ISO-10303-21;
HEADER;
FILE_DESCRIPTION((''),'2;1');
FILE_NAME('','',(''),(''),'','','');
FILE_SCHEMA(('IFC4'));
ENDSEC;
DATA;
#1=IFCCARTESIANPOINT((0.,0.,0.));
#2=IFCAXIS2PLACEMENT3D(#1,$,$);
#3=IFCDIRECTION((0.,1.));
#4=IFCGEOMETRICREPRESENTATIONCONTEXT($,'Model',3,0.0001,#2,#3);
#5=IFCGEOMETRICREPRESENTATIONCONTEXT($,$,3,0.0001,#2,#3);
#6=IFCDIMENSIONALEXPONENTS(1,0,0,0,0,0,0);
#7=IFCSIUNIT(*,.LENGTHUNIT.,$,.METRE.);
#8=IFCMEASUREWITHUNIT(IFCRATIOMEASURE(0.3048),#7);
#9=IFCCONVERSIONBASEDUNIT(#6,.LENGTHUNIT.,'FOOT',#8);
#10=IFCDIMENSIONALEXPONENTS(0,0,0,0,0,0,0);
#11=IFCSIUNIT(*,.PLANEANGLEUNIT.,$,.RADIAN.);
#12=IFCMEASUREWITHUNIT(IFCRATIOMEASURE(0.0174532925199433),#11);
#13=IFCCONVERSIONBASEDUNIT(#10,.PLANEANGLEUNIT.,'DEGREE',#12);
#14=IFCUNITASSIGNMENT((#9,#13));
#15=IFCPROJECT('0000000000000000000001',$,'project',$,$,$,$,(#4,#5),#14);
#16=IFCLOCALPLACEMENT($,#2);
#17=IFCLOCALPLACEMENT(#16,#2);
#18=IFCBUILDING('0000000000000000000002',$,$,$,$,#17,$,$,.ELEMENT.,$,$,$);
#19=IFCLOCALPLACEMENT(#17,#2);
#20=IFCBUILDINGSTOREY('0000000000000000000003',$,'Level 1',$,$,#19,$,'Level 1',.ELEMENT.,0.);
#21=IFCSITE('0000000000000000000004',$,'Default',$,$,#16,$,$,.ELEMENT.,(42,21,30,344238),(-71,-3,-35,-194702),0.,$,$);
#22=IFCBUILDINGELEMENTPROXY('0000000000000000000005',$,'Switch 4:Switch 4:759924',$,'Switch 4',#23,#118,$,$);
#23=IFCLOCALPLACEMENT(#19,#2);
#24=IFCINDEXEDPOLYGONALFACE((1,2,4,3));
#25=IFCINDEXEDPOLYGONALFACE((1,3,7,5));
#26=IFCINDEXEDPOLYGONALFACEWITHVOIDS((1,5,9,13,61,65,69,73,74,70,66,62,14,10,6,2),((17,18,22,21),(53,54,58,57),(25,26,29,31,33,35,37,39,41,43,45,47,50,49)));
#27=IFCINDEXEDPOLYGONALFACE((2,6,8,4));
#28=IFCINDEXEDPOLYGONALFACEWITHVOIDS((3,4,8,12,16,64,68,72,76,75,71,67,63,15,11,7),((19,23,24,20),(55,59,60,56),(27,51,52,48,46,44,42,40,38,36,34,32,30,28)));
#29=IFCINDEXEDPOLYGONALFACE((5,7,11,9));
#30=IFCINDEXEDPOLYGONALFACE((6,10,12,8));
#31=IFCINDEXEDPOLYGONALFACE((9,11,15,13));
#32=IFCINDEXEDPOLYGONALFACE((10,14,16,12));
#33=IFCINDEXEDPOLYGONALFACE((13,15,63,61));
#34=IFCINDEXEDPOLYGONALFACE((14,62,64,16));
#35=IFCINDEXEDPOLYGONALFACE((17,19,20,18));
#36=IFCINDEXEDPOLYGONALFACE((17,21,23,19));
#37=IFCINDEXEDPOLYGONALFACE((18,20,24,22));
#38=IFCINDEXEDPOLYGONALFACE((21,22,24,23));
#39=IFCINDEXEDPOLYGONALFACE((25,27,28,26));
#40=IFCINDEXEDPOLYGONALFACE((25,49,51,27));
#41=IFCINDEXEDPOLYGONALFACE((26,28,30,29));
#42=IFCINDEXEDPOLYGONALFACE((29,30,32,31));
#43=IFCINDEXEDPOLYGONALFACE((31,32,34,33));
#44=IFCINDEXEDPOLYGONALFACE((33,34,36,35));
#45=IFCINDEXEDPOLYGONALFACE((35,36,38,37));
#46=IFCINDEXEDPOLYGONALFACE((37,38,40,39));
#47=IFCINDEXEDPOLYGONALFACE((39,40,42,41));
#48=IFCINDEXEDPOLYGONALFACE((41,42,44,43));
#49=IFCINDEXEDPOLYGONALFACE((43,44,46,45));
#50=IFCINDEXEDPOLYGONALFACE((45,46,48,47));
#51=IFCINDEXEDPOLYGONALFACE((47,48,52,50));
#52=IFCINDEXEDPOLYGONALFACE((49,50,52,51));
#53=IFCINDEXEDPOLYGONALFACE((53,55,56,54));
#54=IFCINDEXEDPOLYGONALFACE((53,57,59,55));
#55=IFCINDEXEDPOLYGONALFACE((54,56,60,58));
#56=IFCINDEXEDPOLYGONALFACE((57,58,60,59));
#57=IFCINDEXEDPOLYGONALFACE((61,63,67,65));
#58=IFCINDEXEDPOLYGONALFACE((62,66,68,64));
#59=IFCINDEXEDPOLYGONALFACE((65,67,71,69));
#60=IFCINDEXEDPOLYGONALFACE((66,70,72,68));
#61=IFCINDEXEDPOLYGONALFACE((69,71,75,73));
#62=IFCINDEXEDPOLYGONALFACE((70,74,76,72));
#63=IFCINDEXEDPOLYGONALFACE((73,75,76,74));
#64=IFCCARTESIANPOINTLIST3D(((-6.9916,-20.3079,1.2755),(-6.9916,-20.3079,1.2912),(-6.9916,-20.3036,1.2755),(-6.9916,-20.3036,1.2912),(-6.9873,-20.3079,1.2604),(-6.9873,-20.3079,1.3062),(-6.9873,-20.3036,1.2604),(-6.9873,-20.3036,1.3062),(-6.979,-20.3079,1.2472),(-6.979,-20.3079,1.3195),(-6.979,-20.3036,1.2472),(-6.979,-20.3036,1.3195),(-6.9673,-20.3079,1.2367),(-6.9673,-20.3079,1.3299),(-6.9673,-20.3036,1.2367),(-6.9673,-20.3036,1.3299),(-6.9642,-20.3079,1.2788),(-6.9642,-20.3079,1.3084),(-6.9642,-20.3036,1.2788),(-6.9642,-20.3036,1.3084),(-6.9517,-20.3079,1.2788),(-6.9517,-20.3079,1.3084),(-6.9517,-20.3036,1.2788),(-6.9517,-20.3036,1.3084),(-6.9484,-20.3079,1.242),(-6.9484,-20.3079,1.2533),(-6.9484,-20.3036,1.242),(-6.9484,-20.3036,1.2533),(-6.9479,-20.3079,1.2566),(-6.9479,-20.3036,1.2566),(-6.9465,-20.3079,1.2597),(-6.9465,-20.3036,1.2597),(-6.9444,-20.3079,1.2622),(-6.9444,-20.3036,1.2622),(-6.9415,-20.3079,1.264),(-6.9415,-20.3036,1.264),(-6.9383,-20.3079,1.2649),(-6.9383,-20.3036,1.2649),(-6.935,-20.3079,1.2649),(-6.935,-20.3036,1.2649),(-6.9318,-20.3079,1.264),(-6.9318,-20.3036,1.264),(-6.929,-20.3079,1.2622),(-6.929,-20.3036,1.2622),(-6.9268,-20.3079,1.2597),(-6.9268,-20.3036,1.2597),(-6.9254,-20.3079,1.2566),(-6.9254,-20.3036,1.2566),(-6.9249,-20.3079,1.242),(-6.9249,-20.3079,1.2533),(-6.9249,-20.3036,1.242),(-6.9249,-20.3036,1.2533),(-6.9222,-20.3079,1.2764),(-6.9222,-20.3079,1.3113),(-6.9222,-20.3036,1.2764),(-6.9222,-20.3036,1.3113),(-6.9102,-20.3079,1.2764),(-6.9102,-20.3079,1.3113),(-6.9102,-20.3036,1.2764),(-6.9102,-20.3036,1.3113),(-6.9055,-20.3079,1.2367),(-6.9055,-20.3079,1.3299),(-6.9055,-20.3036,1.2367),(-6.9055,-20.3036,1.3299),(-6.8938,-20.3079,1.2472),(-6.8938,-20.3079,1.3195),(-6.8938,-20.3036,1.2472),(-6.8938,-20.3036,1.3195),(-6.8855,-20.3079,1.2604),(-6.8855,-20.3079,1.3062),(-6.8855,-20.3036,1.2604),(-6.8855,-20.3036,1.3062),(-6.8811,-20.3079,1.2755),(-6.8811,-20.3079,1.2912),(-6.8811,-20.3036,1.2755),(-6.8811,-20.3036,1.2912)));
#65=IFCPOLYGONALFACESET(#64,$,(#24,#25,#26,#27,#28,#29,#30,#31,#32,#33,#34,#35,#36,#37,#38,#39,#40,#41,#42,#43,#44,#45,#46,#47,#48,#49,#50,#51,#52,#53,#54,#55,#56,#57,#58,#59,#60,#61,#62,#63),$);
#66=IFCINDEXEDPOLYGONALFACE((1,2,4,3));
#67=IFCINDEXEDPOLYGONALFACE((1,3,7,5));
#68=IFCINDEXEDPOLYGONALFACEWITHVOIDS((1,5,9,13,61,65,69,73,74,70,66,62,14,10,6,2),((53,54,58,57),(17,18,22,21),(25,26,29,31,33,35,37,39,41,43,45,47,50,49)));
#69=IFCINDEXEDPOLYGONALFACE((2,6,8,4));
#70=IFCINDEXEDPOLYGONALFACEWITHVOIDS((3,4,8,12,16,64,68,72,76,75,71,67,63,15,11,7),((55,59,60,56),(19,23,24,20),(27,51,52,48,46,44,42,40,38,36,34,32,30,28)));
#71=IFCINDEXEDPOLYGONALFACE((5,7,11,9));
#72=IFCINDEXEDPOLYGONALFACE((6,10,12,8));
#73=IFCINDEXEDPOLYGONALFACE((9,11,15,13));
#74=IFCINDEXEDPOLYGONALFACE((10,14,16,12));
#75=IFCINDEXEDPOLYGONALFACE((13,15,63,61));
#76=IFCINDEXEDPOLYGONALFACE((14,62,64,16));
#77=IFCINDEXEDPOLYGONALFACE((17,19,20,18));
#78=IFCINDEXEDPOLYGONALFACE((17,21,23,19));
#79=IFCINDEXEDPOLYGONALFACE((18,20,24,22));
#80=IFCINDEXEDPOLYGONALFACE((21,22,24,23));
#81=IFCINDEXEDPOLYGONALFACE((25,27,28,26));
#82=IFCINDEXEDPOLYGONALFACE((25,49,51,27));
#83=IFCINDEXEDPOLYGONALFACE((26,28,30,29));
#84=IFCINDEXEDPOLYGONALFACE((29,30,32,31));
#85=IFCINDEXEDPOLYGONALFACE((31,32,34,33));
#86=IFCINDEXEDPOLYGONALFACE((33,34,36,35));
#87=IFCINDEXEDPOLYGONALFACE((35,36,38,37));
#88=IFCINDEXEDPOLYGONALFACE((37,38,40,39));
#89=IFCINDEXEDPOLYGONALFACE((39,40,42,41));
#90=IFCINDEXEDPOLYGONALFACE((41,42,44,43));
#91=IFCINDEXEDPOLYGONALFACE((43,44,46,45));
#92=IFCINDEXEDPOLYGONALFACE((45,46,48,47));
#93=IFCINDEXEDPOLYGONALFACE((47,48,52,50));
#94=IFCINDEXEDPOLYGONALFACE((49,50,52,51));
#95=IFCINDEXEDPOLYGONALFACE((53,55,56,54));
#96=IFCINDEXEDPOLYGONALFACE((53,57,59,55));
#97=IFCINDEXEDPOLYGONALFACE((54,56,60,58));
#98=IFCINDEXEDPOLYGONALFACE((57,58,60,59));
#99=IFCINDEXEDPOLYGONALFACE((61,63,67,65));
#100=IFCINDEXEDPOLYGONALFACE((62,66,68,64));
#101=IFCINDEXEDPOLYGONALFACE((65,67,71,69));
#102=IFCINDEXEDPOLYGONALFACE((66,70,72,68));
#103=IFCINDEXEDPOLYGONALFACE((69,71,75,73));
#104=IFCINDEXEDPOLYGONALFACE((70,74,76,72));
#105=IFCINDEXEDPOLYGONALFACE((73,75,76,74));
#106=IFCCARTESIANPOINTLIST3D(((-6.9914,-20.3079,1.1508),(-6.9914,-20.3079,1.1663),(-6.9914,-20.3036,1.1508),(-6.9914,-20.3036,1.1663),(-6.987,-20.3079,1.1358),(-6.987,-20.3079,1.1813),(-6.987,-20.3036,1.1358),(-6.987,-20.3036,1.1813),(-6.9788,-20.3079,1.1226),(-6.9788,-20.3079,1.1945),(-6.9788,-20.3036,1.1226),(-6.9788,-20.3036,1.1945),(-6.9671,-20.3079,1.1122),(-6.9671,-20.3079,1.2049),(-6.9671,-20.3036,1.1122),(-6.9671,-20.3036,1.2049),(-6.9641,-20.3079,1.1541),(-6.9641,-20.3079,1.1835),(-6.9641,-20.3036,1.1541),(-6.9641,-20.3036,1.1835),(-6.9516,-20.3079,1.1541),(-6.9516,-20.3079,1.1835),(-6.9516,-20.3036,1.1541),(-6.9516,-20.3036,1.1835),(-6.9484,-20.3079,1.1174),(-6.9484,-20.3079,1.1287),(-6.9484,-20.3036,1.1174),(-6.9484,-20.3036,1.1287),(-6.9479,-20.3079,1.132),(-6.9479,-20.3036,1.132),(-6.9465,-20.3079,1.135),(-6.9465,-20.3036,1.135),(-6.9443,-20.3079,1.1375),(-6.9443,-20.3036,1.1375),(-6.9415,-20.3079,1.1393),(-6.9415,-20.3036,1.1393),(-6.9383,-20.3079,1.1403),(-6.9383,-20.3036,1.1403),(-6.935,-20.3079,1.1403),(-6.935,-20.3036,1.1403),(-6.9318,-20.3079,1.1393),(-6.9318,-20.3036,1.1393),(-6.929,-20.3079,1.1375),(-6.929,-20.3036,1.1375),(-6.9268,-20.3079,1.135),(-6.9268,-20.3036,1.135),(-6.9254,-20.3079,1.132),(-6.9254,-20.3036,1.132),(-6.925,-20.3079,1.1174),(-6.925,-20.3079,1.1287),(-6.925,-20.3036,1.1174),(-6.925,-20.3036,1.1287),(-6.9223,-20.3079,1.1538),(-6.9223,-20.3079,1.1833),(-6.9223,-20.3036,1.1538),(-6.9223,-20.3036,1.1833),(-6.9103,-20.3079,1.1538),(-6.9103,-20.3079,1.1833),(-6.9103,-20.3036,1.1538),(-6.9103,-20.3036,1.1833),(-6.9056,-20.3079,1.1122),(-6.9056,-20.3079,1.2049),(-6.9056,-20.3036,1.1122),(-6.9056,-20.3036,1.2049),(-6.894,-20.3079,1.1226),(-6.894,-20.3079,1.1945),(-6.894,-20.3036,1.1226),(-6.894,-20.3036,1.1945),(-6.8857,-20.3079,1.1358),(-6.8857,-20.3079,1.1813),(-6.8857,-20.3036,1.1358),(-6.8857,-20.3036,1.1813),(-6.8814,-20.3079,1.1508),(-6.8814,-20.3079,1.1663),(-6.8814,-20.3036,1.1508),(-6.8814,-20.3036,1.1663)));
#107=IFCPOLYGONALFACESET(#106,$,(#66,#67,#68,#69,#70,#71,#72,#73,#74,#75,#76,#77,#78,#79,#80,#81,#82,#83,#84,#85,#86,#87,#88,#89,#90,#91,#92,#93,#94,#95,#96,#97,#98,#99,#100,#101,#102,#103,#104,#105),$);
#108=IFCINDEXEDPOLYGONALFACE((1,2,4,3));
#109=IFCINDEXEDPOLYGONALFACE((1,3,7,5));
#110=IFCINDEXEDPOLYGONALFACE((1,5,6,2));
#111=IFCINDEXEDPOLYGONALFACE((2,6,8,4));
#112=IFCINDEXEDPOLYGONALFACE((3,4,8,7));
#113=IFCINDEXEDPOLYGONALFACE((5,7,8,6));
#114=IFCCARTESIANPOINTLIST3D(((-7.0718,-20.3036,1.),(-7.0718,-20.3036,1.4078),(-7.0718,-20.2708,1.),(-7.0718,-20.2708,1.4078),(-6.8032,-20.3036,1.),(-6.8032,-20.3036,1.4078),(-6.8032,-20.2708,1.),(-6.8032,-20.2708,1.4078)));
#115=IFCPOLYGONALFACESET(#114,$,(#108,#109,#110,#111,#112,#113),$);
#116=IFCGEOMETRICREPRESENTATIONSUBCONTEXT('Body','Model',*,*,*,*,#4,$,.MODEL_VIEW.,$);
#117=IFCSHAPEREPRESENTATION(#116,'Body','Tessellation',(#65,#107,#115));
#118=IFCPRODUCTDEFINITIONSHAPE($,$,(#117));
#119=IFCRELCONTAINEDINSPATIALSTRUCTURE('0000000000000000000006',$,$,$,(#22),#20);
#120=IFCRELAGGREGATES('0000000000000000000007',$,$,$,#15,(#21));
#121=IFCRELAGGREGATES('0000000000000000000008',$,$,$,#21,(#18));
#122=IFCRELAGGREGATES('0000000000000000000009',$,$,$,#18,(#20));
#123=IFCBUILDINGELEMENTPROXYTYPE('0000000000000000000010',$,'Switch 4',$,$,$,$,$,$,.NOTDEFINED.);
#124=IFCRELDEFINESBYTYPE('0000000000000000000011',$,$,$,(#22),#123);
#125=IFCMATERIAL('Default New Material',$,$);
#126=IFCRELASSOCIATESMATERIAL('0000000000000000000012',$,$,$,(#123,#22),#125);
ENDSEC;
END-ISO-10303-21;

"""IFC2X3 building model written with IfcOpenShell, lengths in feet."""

from ifc_helpers import new_model, entity, si_unit, converted_unit, direction, frame, frame_2d, origin, origin_2d_with_axis, place, context, subcontext, project, spatial, polyline, circle_curve, parameter, trimmed, segment, composite_curve, rectangle, outline, extrude, source, transform, mapped, material, type_object, type_shapes, element, save


model = new_model("IFC2X3")

# Units and contexts
model_context = context("Model", 3, precision=0.0001, world=origin(), true_north=direction((0.0, 1.0)))
context_of_model = context(None, 3, precision=0.0001, world=origin(), true_north=direction((0.0, 1.0)))
body_context = subcontext(model_context, "Body", "Model", "MODEL_VIEW")
ifc_project = project(units=[converted_unit("LENGTHUNIT", "FOOT", entity("IfcRatioMeasure", 0.3048), si_unit("LENGTHUNIT", "METRE"), dimensions=[1, 0, 0, 0, 0, 0, 0]), converted_unit("PLANEANGLEUNIT", "DEGREE", entity("IfcRatioMeasure", 0.0174532925199433), si_unit("PLANEANGLEUNIT", "RADIAN"), dimensions=[0, 0, 0, 0, 0, 0, 0])], contexts=[model_context, context_of_model])

# Site, building, storey
site_placement = place(None, origin())
site = spatial("IfcSite", under=ifc_project, at=site_placement, Name="Default", CompositionType="ELEMENT", RefLatitude=(42, 21, 30, 344238), RefLongitude=(-71, -3, -35, -194702), RefElevation=0.0)
building_placement = place(site_placement, origin())
building = spatial("IfcBuilding", under=site, at=building_placement, CompositionType="ELEMENT")
storey_placement = place(building_placement, origin())
storey = spatial("IfcBuildingStorey", under=building, at=storey_placement, Name="Level 1", LongName="Level 1", CompositionType="ELEMENT", Elevation=0.0)

# Shared definitions
ifc_material_1 = material(Name="Default New Material")

# Building element proxy
building_element_proxy_type_1 = type_object("IfcBuildingElementProxyType", Name="Switch 4", PredefinedType="NOTDEFINED", material=ifc_material_1)
shared_shape_1 = source(origin(), body_context, "Body", "SweptSolid", [
    extrude(outline(composite_curve([segment(polyline([(-0.0309, -0.0466), (0.0309, -0.0466)]), True, "CONTINUOUS"), segment(trimmed(circle_curve(frame_2d((-0.0003, 0.0), x_axis=(-1.0, 0.0)), 0.0561), [parameter(123.794741)], [parameter(236.205259)], True, "PARAMETER"), True, "CONTINUOUS"), segment(polyline([(0.0309, 0.0466), (-0.0309, 0.0466)]), True, "CONTINUOUS"), segment(trimmed(circle_curve(frame_2d((0.0003, 0.0), x_axis=(1.0, 0.0)), 0.0561), [parameter(123.794741)], [parameter(236.205259)], True, "PARAMETER"), True, "CONTINUOUS")], self_intersect=False), holes=[polyline([(0.0142, 0.0279), (0.0262, 0.0279), (0.0262, -0.0069), (0.0142, -0.0069), (0.0142, 0.0279)]), polyline([(-0.0153, 0.025), (-0.0153, -0.0045), (-0.0278, -0.0045), (-0.0278, 0.025), (-0.0153, 0.025)]), composite_curve([segment(polyline([(-0.012, -0.0413), (-0.012, -0.03)]), True, "CONTINUOUS"), segment(trimmed(circle_curve(frame_2d((-0.0003, -0.03), x_axis=(-1.0, 0.0)), 0.0117), [parameter(180.0)], [parameter(0.0)], True, "PARAMETER"), False, "CONTINUOUS"), segment(polyline([(0.0115, -0.03), (0.0115, -0.0413)]), True, "CONTINUOUS"), segment(polyline([(0.0115, -0.0413), (-0.012, -0.0413)]), True, "CONTINUOUS")], self_intersect=False)]), frame((-0.0011, 0.0328, 0.2833), z_axis=(0.0, 1.0, 0.0), x_axis=(-1.0, 0.0, 0.0)), (0.0, 0.0, 1.0), 0.0042),
    extrude(outline(composite_curve([segment(polyline([(-0.0308, -0.0464), (0.0308, -0.0464)]), True, "CONTINUOUS"), segment(trimmed(circle_curve(frame_2d((-0.0003, 0.0), x_axis=(-1.0, 0.0)), 0.0558), [parameter(123.794741)], [parameter(236.205259)], True, "PARAMETER"), True, "CONTINUOUS"), segment(polyline([(0.0308, 0.0464), (-0.0308, 0.0464)]), True, "CONTINUOUS"), segment(trimmed(circle_curve(frame_2d((0.0003, 0.0), x_axis=(1.0, 0.0)), 0.0558), [parameter(123.794741)], [parameter(236.205259)], True, "PARAMETER"), True, "CONTINUOUS")], self_intersect=False), holes=[polyline([(0.0141, 0.0247), (0.026, 0.0247), (0.026, -0.0047), (0.0141, -0.0047), (0.0141, 0.0247)]), polyline([(-0.0152, 0.0249), (-0.0152, -0.0045), (-0.0277, -0.0045), (-0.0277, 0.0249), (-0.0152, 0.0249)]), composite_curve([segment(polyline([(-0.012, -0.0411), (-0.012, -0.0299)]), True, "CONTINUOUS"), segment(trimmed(circle_curve(frame_2d((-0.0003, -0.0299), x_axis=(-1.0, 0.0)), 0.0117), [parameter(180.0)], [parameter(0.0)], True, "PARAMETER"), False, "CONTINUOUS"), segment(polyline([(0.0114, -0.0299), (0.0114, -0.0411)]), True, "CONTINUOUS"), segment(polyline([(0.0114, -0.0411), (-0.012, -0.0411)]), True, "CONTINUOUS")], self_intersect=False)]), frame((-0.0011, 0.0328, 0.1586), z_axis=(0.0, 1.0, 0.0), x_axis=(-1.0, 0.0, 0.0)), (0.0, 0.0, 1.0), 0.0042),
    extrude(rectangle(XDim=0.0328, YDim=0.2687, at=origin_2d_with_axis()), frame((0.0, 0.0164, 0.0), z_axis=(0.0, 0.0, 1.0), x_axis=(0.0, -1.0, 0.0)), (0.0, 0.0, 1.0), 0.4078),
])
type_shapes(building_element_proxy_type_1, [shared_shape_1])
for number, where, z_axis, x_axis, name in (
    (1, (-6.9375, -20.2708, 1.0), (0.0, 0.0, 1.0), (-1.0, 0.0, 0.0), "Switch 4:Switch 4:759924"),
):
    element("IfcBuildingElementProxy", number, at=place(storey_placement, frame(where, z_axis=z_axis, x_axis=x_axis)), inside=storey, type_object=building_element_proxy_type_1, material=ifc_material_1, Name=name, ObjectType="Switch 4", context=body_context, shape_type="MappedRepresentation", body=[
        mapped(shared_shape_1, transform((0.0, 0.0, 0.0), scale=1.0)),
    ])

save(model, "model.ifc")
